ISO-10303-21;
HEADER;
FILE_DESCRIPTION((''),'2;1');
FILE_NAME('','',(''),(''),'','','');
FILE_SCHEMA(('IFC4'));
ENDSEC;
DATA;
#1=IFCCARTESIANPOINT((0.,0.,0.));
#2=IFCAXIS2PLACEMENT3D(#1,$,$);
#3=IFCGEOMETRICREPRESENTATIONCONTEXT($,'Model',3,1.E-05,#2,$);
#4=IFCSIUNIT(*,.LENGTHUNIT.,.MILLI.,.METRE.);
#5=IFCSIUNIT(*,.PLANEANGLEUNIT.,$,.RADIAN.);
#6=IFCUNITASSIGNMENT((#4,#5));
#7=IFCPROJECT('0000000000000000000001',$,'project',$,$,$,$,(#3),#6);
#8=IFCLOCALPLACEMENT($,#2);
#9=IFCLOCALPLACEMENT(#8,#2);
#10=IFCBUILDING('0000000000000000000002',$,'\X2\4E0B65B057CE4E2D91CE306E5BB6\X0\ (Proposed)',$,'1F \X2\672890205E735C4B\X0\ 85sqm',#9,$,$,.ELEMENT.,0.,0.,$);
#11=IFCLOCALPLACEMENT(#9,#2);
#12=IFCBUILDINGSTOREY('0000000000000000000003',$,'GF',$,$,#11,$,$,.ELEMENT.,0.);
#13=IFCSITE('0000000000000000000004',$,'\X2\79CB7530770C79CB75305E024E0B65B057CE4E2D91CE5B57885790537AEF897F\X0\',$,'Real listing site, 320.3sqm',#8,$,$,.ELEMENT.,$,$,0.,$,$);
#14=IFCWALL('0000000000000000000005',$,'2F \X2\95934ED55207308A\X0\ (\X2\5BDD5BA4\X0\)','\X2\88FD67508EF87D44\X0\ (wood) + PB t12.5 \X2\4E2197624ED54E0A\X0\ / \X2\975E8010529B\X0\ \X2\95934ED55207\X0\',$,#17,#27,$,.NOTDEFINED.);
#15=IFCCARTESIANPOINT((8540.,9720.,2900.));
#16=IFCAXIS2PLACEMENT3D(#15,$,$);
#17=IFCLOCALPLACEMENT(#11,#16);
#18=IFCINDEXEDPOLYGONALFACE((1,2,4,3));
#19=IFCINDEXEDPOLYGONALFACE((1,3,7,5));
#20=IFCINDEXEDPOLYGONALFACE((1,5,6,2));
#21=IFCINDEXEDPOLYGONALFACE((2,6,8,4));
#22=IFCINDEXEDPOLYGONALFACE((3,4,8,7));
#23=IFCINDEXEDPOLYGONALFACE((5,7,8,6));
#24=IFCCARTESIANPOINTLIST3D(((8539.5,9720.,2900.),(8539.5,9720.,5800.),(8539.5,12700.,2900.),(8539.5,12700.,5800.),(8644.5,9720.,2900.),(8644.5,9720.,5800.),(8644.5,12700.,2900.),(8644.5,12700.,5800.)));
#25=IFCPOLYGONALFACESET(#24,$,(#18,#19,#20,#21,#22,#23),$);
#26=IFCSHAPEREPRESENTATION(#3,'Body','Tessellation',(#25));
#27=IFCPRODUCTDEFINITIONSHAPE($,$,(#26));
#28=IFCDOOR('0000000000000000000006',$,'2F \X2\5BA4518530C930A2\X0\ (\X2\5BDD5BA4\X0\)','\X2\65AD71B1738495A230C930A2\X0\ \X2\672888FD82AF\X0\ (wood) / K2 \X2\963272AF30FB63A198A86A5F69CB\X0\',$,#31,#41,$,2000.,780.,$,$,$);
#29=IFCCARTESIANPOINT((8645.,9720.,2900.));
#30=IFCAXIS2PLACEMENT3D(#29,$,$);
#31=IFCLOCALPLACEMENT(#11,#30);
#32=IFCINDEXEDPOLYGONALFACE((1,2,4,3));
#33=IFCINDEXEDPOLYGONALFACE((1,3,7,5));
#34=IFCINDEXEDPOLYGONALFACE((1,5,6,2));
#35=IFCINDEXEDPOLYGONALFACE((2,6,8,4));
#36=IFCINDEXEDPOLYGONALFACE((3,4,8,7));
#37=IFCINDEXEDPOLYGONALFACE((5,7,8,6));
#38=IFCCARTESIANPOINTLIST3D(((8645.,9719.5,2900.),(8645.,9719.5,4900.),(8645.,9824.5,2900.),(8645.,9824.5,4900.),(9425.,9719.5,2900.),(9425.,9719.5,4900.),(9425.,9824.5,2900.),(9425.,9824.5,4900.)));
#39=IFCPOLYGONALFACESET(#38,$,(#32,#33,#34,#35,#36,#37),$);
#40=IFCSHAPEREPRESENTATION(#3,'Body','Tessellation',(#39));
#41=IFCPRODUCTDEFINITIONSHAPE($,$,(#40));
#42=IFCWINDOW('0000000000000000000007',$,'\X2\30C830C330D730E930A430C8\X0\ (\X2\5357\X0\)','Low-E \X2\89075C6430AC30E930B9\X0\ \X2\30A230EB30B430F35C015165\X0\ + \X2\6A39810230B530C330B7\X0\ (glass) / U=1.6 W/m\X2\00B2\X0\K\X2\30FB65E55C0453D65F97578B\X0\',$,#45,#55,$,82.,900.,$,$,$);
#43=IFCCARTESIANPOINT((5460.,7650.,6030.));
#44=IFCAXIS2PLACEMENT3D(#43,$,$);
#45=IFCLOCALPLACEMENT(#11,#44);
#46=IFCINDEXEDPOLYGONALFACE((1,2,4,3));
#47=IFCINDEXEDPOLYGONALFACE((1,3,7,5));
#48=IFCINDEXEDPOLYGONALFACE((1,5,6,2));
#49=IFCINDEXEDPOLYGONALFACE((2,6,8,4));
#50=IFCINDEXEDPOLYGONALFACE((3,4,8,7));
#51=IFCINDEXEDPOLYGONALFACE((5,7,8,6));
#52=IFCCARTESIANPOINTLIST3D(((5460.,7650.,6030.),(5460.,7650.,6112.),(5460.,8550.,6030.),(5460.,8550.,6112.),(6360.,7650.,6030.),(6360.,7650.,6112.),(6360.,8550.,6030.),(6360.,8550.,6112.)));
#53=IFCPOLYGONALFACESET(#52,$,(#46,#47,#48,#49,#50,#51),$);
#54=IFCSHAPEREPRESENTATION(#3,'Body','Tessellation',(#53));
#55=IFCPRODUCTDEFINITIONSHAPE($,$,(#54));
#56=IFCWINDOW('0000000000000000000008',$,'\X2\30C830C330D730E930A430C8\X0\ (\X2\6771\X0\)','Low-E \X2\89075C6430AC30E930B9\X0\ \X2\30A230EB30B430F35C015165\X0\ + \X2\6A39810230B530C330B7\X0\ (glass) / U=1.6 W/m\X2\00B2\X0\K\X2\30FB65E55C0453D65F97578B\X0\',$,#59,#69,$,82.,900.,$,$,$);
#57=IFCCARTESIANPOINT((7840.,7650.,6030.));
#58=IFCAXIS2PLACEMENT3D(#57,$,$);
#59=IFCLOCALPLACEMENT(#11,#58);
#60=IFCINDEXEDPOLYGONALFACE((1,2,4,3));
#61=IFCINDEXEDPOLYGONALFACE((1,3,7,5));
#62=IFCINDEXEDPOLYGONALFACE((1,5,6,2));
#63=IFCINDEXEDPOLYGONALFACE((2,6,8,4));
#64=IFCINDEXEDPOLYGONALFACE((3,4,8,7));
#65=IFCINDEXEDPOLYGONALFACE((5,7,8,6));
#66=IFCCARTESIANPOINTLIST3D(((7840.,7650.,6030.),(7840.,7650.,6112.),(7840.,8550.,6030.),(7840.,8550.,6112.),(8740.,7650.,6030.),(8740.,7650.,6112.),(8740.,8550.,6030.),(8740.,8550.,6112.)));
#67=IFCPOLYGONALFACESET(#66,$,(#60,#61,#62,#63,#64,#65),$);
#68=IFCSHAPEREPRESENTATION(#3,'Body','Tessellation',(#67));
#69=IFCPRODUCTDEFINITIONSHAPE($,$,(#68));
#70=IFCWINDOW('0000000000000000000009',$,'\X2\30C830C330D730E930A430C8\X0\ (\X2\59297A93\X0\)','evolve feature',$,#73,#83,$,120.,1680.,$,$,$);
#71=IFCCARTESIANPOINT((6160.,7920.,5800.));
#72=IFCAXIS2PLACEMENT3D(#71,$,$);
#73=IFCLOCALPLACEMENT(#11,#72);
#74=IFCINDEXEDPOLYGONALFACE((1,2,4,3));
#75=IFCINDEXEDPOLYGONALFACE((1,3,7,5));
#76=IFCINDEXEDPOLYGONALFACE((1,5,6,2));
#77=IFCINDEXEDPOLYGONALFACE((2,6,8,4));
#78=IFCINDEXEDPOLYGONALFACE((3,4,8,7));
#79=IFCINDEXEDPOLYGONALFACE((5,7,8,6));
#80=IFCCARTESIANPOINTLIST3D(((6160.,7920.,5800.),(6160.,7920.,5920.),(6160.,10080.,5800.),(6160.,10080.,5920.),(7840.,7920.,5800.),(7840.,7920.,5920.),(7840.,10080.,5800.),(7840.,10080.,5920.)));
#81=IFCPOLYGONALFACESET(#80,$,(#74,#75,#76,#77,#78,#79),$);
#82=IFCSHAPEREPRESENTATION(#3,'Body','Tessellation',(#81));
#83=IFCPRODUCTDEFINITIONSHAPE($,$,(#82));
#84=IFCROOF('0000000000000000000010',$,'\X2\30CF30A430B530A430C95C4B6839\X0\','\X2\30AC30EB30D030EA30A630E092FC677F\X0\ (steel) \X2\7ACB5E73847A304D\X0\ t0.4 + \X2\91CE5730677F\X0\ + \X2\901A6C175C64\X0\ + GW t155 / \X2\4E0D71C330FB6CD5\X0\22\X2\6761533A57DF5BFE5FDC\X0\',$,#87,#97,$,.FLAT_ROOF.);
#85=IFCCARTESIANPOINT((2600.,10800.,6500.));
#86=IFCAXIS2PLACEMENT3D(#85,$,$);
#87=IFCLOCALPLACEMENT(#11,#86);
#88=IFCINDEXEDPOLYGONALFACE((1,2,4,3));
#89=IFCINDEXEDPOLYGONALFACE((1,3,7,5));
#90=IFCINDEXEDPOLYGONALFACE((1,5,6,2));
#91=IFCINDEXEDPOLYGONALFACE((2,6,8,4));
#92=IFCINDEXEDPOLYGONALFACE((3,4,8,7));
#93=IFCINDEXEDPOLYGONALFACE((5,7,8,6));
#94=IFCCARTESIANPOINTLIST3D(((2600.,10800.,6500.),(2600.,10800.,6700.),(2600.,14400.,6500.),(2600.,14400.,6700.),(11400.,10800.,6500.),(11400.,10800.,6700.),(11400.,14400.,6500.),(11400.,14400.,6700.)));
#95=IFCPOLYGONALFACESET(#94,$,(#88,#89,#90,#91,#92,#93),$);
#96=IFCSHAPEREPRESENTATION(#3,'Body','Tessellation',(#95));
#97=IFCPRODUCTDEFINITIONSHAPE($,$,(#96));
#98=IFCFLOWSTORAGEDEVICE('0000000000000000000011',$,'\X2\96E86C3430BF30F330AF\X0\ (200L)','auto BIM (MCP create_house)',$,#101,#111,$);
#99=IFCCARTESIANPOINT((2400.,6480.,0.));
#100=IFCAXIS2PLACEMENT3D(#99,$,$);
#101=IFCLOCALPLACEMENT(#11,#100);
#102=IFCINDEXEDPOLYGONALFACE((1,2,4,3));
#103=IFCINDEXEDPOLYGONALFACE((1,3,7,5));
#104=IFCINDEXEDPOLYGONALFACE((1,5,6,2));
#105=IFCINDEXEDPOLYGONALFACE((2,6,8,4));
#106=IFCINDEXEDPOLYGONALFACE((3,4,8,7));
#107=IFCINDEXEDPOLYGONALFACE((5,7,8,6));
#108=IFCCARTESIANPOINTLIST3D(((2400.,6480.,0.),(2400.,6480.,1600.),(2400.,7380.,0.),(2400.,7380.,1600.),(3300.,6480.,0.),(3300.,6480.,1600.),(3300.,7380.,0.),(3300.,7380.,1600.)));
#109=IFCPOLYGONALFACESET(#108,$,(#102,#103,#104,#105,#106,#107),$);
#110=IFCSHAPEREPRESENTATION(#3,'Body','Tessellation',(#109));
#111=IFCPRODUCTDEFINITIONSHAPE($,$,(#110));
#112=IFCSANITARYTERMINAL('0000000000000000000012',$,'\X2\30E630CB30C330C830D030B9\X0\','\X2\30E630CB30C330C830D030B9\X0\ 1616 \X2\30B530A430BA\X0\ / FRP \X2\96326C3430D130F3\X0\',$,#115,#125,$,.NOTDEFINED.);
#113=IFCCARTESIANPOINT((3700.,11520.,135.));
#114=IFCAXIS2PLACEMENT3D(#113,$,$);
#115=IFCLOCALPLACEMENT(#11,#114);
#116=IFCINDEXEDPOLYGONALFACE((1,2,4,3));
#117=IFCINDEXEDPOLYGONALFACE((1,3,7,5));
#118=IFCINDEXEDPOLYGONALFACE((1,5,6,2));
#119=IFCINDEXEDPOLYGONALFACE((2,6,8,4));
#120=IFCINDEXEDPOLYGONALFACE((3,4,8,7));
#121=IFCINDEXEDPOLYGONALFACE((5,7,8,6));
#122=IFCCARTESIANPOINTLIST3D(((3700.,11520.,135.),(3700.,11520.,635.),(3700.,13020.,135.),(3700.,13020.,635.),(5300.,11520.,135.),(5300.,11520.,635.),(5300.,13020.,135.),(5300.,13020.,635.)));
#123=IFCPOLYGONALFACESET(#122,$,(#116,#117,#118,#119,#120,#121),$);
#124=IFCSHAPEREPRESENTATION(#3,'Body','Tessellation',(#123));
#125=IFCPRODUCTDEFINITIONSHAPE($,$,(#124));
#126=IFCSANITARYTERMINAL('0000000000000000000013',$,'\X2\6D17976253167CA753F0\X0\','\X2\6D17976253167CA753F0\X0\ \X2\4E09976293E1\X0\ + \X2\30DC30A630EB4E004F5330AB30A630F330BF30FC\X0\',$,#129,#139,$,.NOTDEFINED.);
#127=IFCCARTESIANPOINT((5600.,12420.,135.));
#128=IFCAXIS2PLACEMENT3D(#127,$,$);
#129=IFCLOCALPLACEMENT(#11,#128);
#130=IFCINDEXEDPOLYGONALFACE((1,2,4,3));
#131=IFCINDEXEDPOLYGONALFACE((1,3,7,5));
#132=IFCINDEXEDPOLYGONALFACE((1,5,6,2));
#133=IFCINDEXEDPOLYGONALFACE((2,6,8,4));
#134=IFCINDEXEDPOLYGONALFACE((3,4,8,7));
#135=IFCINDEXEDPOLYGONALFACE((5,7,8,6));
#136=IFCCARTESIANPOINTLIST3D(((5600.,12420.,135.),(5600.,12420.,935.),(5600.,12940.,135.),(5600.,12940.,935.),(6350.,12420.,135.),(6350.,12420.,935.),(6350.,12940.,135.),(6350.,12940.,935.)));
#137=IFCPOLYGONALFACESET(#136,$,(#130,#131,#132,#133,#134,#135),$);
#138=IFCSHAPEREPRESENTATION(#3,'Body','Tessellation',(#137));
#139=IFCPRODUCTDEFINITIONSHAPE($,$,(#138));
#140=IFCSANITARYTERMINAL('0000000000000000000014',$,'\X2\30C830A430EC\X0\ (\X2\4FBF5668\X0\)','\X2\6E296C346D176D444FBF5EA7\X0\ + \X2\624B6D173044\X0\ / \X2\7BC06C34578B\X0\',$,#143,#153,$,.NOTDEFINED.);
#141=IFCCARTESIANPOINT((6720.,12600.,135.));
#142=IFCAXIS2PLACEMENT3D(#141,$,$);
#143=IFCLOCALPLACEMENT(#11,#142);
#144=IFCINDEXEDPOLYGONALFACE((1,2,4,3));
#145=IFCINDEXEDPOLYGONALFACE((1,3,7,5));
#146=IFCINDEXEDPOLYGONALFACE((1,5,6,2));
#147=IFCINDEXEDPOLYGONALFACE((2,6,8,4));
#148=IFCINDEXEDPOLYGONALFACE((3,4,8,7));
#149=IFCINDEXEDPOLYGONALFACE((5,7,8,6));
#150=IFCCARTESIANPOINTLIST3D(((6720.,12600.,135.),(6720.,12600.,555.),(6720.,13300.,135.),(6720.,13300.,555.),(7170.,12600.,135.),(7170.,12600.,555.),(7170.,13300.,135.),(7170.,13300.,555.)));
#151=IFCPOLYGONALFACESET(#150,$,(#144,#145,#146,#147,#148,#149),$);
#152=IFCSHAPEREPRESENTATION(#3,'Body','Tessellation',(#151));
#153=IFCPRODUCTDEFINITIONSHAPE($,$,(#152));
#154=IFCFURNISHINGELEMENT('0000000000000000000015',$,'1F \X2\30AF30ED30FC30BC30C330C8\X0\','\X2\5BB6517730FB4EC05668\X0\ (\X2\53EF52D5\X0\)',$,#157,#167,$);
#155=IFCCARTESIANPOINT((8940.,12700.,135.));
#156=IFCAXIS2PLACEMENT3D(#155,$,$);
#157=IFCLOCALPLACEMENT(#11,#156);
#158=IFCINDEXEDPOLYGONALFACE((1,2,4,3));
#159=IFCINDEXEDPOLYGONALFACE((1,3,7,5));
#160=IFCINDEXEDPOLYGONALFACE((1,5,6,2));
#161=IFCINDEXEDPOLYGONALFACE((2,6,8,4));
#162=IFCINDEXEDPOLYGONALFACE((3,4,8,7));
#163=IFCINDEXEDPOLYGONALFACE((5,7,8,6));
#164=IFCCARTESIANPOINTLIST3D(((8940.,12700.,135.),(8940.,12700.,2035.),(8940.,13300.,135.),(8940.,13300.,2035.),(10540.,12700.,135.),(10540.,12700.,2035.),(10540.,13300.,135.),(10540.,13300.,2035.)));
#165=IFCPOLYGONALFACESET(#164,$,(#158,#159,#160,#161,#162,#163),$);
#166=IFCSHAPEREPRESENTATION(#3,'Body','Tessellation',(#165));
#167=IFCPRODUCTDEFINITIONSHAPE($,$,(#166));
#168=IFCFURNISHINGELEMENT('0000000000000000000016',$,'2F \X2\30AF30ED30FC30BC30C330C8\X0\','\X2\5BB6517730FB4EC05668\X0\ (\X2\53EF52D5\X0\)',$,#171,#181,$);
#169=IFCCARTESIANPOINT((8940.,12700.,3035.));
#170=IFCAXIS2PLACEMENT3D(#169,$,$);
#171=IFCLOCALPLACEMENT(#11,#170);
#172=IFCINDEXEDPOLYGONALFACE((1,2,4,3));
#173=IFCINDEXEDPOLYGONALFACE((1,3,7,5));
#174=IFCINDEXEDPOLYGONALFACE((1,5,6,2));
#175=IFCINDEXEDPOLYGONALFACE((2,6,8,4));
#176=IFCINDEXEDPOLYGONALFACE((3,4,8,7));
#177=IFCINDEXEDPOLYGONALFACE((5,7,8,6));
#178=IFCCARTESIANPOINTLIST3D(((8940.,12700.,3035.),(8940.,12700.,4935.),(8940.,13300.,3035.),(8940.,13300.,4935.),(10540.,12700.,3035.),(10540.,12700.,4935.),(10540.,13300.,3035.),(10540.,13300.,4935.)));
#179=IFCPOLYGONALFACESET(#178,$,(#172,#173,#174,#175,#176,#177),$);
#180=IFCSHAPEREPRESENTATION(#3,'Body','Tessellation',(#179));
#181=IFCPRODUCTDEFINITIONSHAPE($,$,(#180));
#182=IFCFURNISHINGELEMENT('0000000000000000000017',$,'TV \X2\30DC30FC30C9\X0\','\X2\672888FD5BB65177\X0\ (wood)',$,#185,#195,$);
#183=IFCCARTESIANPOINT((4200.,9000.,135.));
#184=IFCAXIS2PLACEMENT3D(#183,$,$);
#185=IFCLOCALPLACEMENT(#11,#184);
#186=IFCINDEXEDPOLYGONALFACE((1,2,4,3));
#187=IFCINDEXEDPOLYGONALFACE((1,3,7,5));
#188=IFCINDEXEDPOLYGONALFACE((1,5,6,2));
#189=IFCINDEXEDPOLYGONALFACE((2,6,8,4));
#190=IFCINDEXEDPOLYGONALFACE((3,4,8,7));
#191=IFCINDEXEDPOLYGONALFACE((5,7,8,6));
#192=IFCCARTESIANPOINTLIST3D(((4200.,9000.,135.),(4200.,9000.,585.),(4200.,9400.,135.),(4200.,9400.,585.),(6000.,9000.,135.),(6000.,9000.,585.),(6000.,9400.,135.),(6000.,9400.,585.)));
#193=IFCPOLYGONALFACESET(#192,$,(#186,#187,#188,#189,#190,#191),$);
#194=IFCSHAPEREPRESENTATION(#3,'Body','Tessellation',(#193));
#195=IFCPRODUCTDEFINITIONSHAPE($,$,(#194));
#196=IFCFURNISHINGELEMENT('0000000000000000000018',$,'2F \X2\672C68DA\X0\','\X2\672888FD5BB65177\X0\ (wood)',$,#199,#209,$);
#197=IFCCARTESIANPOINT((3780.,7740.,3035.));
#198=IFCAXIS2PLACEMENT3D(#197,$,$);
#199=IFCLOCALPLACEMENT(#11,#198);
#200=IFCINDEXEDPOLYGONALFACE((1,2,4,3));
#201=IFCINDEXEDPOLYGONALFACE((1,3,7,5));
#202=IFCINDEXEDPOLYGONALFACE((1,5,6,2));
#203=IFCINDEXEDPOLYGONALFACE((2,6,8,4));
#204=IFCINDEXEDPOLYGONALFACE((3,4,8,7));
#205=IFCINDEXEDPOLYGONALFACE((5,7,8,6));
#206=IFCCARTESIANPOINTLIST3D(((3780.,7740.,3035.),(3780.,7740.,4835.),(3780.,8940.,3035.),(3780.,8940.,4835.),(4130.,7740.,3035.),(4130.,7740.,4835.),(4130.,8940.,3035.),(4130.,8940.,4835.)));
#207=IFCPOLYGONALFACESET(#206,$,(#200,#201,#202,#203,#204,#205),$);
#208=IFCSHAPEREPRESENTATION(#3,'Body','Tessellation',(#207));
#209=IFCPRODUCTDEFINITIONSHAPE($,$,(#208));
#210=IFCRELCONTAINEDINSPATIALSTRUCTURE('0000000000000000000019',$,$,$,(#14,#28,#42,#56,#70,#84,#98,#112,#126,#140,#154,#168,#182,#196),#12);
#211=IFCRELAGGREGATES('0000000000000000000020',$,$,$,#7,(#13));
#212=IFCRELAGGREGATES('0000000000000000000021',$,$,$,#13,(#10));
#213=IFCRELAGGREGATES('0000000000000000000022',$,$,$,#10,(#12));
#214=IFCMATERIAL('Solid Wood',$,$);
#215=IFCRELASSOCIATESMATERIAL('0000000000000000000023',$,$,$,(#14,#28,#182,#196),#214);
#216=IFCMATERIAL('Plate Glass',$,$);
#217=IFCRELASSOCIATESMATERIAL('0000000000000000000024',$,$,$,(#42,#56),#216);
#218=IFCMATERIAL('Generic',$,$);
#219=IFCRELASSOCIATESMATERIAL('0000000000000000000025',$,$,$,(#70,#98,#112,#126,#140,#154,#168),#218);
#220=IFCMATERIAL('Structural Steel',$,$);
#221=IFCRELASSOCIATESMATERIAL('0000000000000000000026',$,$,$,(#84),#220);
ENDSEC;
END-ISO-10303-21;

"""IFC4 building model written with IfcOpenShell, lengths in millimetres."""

from ifc_helpers import new_model, si_unit, frame, frame_2d, origin, place, context, project, spatial, rectangle, extrude, material, element, save


model = new_model("IFC4")

# Units and contexts
model_context = context("Model", 3, precision=1e-05, world=origin())
ifc_project = project(units=[si_unit("LENGTHUNIT", "METRE", prefix="MILLI"), si_unit("PLANEANGLEUNIT", "RADIAN")], contexts=[model_context])

# Site, building, storey
site_placement = place(None, origin())
site = spatial("IfcSite", under=ifc_project, at=site_placement, Name="秋田県秋田市下新城中野字街道端西", ObjectType="Real listing site, 320.3sqm", CompositionType="ELEMENT", RefElevation=0.0)
building_placement = place(site_placement, origin())
building = spatial("IfcBuilding", under=site, at=building_placement, Name="下新城中野の家 (Proposed)", ObjectType="1F 木造平屋 85sqm", CompositionType="ELEMENT", ElevationOfRefHeight=0.0, ElevationOfTerrain=0.0)
storey_placement = place(building_placement, origin())
storey = spatial("IfcBuildingStorey", under=building, at=storey_placement, Name="GF", CompositionType="ELEMENT", Elevation=0.0)

# Shared definitions
ifc_material_1 = material(Name="Solid Wood")
ifc_material_2 = material(Name="Plate Glass")

# Wall
wall_1_placement = place(storey_placement, frame((8540.0, 9720.0, 2900.0)))
element("IfcWall", 1, at=wall_1_placement, inside=storey, material=ifc_material_1, Name="2F 間仕切り (寝室)", Description="製材軸組 (wood) + PB t12.5 両面仕上 / 非耐力 間仕切", PredefinedType="NOTDEFINED", context=model_context, shape_type="SweptSolid", body=[
    extrude(rectangle(XDim=105.0, YDim=2980.0, at=frame_2d((52.0, 1490.0))), frame((8540.0, 9720.0, 2900.0)), (0.0, 0.0, 1.0), 2900.0),
])

# Door
door_1_placement = place(storey_placement, frame((8645.0, 9720.0, 2900.0)))
element("IfcDoor", 2, at=door_1_placement, inside=storey, material=ifc_material_1, Name="2F 室内ドア (寝室)", Description="断熱玄関ドア 木製芯 (wood) / K2 防犯・採風機構", OverallHeight=2000.0, OverallWidth=780.0, context=model_context, shape_type="SweptSolid", body=[
    extrude(rectangle(XDim=780.0, YDim=105.0, at=frame_2d((390.0, 52.0))), frame((8645.0, 9720.0, 2900.0)), (0.0, 0.0, 1.0), 2000.0),
])

# Windows
window_1_placement = place(storey_placement, frame((5460.0, 7650.0, 6030.0)))
element("IfcWindow", 3, at=window_1_placement, inside=storey, material=ifc_material_2, Name="トップライト (南)", Description="Low-E 複層ガラス アルゴン封入 + 樹脂サッシ (glass) / U=1.6 W/m²K・日射取得型", OverallHeight=82.0, OverallWidth=900.0, context=model_context, shape_type="SweptSolid", body=[
    extrude(rectangle(XDim=900.0, YDim=900.0, at=frame_2d((450.0, 450.0))), frame((5460.0, 7650.0, 6030.0)), (0.0, 0.0, 1.0), 82.0),
])
window_2_placement = place(storey_placement, frame((7840.0, 7650.0, 6030.0)))
element("IfcWindow", 4, at=window_2_placement, inside=storey, material=ifc_material_2, Name="トップライト (東)", Description="Low-E 複層ガラス アルゴン封入 + 樹脂サッシ (glass) / U=1.6 W/m²K・日射取得型", OverallHeight=82.0, OverallWidth=900.0, context=model_context, shape_type="SweptSolid", body=[
    extrude(rectangle(XDim=900.0, YDim=900.0, at=frame_2d((450.0, 450.0))), frame((7840.0, 7650.0, 6030.0)), (0.0, 0.0, 1.0), 82.0),
])
ifc_material_3 = material(Name="Generic")
window_3_placement = place(storey_placement, frame((6160.0, 7920.0, 5800.0)))
element("IfcWindow", 5, at=window_3_placement, inside=storey, material=ifc_material_3, Name="トップライト (天窓)", Description="evolve feature", OverallHeight=120.0, OverallWidth=1680.0, context=model_context, shape_type="SweptSolid", body=[
    extrude(rectangle(XDim=1680.0, YDim=2160.0, at=frame_2d((840.0, 1080.0))), frame((6160.0, 7920.0, 5800.0)), (0.0, 0.0, 1.0), 120.0),
])

# Roof
ifc_material_4 = material(Name="Structural Steel")
roof_placement = place(storey_placement, frame((2600.0, 10800.0, 6500.0)))
element("IfcRoof", 6, at=roof_placement, inside=storey, material=ifc_material_4, Name="ハイサイド屋根", Description="ガルバリウム鋼板 (steel) 立平葺き t0.4 + 野地板 + 通気層 + GW t155 / 不燃・法22条区域対応", PredefinedType="FLAT_ROOF", context=model_context, shape_type="SweptSolid", body=[
    extrude(rectangle(XDim=8800.0, YDim=3600.0, at=frame_2d((4400.0, 1800.0))), frame((2600.0, 10800.0, 6500.0)), (0.0, 0.0, 1.0), 200.0),
])

# Flow storage device
flow_storage_device_placement = place(storey_placement, frame((2400.0, 6480.0, 0.0)))
element("IfcFlowStorageDevice", 7, at=flow_storage_device_placement, inside=storey, material=ifc_material_3, Name="雨水タンク (200L)", Description="auto BIM (MCP create_house)", context=model_context, shape_type="SweptSolid", body=[
    extrude(rectangle(XDim=900.0, YDim=900.0, at=frame_2d((450.0, 450.0))), frame((2400.0, 6480.0, 0.0)), (0.0, 0.0, 1.0), 1600.0),
])

# Sanitary terminals
sanitary_terminal_1_placement = place(storey_placement, frame((3700.0, 11520.0, 135.0)))
element("IfcSanitaryTerminal", 8, at=sanitary_terminal_1_placement, inside=storey, material=ifc_material_3, Name="ユニットバス", Description="ユニットバス 1616 サイズ / FRP 防水パン", PredefinedType="NOTDEFINED", context=model_context, shape_type="SweptSolid", body=[
    extrude(rectangle(XDim=1600.0, YDim=1500.0, at=frame_2d((800.0, 750.0))), frame((3700.0, 11520.0, 135.0)), (0.0, 0.0, 1.0), 500.0),
])
sanitary_terminal_2_placement = place(storey_placement, frame((5600.0, 12420.0, 135.0)))
element("IfcSanitaryTerminal", 9, at=sanitary_terminal_2_placement, inside=storey, material=ifc_material_3, Name="洗面化粧台", Description="洗面化粧台 三面鏡 + ボウル一体カウンター", PredefinedType="NOTDEFINED", context=model_context, shape_type="SweptSolid", body=[
    extrude(rectangle(XDim=750.0, YDim=520.0, at=frame_2d((375.0, 260.0))), frame((5600.0, 12420.0, 135.0)), (0.0, 0.0, 1.0), 800.0),
])
sanitary_terminal_3_placement = place(storey_placement, frame((6720.0, 12600.0, 135.0)))
element("IfcSanitaryTerminal", 10, at=sanitary_terminal_3_placement, inside=storey, material=ifc_material_3, Name="トイレ (便器)", Description="温水洗浄便座 + 手洗い / 節水型", PredefinedType="NOTDEFINED", context=model_context, shape_type="SweptSolid", body=[
    extrude(rectangle(XDim=450.0, YDim=700.0, at=frame_2d((225.0, 350.0))), frame((6720.0, 12600.0, 135.0)), (0.0, 0.0, 1.0), 420.0),
])

# Furnishing elements
furnishing_1_placement = place(storey_placement, frame((8940.0, 12700.0, 135.0)))
element("IfcFurnishingElement", 11, at=furnishing_1_placement, inside=storey, material=ifc_material_3, Name="1F クローゼット", Description="家具・什器 (可動)", context=model_context, shape_type="SweptSolid", body=[
    extrude(rectangle(XDim=1600.0, YDim=600.0, at=frame_2d((800.0, 300.0))), frame((8940.0, 12700.0, 135.0)), (0.0, 0.0, 1.0), 1900.0),
])
furnishing_2_placement = place(storey_placement, frame((8940.0, 12700.0, 3035.0)))
element("IfcFurnishingElement", 12, at=furnishing_2_placement, inside=storey, material=ifc_material_3, Name="2F クローゼット", Description="家具・什器 (可動)", context=model_context, shape_type="SweptSolid", body=[
    extrude(rectangle(XDim=1600.0, YDim=600.0, at=frame_2d((800.0, 300.0))), frame((8940.0, 12700.0, 3035.0)), (0.0, 0.0, 1.0), 1900.0),
])
furnishing_3_placement = place(storey_placement, frame((4200.0, 9000.0, 135.0)))
element("IfcFurnishingElement", 13, at=furnishing_3_placement, inside=storey, material=ifc_material_1, Name="TV ボード", Description="木製家具 (wood)", context=model_context, shape_type="SweptSolid", body=[
    extrude(rectangle(XDim=1800.0, YDim=400.0, at=frame_2d((900.0, 200.0))), frame((4200.0, 9000.0, 135.0)), (0.0, 0.0, 1.0), 450.0),
])
furnishing_4_placement = place(storey_placement, frame((3780.0, 7740.0, 3035.0)))
element("IfcFurnishingElement", 14, at=furnishing_4_placement, inside=storey, material=ifc_material_1, Name="2F 本棚", Description="木製家具 (wood)", context=model_context, shape_type="SweptSolid", body=[
    extrude(rectangle(XDim=350.0, YDim=1200.0, at=frame_2d((175.0, 600.0))), frame((3780.0, 7740.0, 3035.0)), (0.0, 0.0, 1.0), 1800.0),
])

save(model, "model.ifc")
